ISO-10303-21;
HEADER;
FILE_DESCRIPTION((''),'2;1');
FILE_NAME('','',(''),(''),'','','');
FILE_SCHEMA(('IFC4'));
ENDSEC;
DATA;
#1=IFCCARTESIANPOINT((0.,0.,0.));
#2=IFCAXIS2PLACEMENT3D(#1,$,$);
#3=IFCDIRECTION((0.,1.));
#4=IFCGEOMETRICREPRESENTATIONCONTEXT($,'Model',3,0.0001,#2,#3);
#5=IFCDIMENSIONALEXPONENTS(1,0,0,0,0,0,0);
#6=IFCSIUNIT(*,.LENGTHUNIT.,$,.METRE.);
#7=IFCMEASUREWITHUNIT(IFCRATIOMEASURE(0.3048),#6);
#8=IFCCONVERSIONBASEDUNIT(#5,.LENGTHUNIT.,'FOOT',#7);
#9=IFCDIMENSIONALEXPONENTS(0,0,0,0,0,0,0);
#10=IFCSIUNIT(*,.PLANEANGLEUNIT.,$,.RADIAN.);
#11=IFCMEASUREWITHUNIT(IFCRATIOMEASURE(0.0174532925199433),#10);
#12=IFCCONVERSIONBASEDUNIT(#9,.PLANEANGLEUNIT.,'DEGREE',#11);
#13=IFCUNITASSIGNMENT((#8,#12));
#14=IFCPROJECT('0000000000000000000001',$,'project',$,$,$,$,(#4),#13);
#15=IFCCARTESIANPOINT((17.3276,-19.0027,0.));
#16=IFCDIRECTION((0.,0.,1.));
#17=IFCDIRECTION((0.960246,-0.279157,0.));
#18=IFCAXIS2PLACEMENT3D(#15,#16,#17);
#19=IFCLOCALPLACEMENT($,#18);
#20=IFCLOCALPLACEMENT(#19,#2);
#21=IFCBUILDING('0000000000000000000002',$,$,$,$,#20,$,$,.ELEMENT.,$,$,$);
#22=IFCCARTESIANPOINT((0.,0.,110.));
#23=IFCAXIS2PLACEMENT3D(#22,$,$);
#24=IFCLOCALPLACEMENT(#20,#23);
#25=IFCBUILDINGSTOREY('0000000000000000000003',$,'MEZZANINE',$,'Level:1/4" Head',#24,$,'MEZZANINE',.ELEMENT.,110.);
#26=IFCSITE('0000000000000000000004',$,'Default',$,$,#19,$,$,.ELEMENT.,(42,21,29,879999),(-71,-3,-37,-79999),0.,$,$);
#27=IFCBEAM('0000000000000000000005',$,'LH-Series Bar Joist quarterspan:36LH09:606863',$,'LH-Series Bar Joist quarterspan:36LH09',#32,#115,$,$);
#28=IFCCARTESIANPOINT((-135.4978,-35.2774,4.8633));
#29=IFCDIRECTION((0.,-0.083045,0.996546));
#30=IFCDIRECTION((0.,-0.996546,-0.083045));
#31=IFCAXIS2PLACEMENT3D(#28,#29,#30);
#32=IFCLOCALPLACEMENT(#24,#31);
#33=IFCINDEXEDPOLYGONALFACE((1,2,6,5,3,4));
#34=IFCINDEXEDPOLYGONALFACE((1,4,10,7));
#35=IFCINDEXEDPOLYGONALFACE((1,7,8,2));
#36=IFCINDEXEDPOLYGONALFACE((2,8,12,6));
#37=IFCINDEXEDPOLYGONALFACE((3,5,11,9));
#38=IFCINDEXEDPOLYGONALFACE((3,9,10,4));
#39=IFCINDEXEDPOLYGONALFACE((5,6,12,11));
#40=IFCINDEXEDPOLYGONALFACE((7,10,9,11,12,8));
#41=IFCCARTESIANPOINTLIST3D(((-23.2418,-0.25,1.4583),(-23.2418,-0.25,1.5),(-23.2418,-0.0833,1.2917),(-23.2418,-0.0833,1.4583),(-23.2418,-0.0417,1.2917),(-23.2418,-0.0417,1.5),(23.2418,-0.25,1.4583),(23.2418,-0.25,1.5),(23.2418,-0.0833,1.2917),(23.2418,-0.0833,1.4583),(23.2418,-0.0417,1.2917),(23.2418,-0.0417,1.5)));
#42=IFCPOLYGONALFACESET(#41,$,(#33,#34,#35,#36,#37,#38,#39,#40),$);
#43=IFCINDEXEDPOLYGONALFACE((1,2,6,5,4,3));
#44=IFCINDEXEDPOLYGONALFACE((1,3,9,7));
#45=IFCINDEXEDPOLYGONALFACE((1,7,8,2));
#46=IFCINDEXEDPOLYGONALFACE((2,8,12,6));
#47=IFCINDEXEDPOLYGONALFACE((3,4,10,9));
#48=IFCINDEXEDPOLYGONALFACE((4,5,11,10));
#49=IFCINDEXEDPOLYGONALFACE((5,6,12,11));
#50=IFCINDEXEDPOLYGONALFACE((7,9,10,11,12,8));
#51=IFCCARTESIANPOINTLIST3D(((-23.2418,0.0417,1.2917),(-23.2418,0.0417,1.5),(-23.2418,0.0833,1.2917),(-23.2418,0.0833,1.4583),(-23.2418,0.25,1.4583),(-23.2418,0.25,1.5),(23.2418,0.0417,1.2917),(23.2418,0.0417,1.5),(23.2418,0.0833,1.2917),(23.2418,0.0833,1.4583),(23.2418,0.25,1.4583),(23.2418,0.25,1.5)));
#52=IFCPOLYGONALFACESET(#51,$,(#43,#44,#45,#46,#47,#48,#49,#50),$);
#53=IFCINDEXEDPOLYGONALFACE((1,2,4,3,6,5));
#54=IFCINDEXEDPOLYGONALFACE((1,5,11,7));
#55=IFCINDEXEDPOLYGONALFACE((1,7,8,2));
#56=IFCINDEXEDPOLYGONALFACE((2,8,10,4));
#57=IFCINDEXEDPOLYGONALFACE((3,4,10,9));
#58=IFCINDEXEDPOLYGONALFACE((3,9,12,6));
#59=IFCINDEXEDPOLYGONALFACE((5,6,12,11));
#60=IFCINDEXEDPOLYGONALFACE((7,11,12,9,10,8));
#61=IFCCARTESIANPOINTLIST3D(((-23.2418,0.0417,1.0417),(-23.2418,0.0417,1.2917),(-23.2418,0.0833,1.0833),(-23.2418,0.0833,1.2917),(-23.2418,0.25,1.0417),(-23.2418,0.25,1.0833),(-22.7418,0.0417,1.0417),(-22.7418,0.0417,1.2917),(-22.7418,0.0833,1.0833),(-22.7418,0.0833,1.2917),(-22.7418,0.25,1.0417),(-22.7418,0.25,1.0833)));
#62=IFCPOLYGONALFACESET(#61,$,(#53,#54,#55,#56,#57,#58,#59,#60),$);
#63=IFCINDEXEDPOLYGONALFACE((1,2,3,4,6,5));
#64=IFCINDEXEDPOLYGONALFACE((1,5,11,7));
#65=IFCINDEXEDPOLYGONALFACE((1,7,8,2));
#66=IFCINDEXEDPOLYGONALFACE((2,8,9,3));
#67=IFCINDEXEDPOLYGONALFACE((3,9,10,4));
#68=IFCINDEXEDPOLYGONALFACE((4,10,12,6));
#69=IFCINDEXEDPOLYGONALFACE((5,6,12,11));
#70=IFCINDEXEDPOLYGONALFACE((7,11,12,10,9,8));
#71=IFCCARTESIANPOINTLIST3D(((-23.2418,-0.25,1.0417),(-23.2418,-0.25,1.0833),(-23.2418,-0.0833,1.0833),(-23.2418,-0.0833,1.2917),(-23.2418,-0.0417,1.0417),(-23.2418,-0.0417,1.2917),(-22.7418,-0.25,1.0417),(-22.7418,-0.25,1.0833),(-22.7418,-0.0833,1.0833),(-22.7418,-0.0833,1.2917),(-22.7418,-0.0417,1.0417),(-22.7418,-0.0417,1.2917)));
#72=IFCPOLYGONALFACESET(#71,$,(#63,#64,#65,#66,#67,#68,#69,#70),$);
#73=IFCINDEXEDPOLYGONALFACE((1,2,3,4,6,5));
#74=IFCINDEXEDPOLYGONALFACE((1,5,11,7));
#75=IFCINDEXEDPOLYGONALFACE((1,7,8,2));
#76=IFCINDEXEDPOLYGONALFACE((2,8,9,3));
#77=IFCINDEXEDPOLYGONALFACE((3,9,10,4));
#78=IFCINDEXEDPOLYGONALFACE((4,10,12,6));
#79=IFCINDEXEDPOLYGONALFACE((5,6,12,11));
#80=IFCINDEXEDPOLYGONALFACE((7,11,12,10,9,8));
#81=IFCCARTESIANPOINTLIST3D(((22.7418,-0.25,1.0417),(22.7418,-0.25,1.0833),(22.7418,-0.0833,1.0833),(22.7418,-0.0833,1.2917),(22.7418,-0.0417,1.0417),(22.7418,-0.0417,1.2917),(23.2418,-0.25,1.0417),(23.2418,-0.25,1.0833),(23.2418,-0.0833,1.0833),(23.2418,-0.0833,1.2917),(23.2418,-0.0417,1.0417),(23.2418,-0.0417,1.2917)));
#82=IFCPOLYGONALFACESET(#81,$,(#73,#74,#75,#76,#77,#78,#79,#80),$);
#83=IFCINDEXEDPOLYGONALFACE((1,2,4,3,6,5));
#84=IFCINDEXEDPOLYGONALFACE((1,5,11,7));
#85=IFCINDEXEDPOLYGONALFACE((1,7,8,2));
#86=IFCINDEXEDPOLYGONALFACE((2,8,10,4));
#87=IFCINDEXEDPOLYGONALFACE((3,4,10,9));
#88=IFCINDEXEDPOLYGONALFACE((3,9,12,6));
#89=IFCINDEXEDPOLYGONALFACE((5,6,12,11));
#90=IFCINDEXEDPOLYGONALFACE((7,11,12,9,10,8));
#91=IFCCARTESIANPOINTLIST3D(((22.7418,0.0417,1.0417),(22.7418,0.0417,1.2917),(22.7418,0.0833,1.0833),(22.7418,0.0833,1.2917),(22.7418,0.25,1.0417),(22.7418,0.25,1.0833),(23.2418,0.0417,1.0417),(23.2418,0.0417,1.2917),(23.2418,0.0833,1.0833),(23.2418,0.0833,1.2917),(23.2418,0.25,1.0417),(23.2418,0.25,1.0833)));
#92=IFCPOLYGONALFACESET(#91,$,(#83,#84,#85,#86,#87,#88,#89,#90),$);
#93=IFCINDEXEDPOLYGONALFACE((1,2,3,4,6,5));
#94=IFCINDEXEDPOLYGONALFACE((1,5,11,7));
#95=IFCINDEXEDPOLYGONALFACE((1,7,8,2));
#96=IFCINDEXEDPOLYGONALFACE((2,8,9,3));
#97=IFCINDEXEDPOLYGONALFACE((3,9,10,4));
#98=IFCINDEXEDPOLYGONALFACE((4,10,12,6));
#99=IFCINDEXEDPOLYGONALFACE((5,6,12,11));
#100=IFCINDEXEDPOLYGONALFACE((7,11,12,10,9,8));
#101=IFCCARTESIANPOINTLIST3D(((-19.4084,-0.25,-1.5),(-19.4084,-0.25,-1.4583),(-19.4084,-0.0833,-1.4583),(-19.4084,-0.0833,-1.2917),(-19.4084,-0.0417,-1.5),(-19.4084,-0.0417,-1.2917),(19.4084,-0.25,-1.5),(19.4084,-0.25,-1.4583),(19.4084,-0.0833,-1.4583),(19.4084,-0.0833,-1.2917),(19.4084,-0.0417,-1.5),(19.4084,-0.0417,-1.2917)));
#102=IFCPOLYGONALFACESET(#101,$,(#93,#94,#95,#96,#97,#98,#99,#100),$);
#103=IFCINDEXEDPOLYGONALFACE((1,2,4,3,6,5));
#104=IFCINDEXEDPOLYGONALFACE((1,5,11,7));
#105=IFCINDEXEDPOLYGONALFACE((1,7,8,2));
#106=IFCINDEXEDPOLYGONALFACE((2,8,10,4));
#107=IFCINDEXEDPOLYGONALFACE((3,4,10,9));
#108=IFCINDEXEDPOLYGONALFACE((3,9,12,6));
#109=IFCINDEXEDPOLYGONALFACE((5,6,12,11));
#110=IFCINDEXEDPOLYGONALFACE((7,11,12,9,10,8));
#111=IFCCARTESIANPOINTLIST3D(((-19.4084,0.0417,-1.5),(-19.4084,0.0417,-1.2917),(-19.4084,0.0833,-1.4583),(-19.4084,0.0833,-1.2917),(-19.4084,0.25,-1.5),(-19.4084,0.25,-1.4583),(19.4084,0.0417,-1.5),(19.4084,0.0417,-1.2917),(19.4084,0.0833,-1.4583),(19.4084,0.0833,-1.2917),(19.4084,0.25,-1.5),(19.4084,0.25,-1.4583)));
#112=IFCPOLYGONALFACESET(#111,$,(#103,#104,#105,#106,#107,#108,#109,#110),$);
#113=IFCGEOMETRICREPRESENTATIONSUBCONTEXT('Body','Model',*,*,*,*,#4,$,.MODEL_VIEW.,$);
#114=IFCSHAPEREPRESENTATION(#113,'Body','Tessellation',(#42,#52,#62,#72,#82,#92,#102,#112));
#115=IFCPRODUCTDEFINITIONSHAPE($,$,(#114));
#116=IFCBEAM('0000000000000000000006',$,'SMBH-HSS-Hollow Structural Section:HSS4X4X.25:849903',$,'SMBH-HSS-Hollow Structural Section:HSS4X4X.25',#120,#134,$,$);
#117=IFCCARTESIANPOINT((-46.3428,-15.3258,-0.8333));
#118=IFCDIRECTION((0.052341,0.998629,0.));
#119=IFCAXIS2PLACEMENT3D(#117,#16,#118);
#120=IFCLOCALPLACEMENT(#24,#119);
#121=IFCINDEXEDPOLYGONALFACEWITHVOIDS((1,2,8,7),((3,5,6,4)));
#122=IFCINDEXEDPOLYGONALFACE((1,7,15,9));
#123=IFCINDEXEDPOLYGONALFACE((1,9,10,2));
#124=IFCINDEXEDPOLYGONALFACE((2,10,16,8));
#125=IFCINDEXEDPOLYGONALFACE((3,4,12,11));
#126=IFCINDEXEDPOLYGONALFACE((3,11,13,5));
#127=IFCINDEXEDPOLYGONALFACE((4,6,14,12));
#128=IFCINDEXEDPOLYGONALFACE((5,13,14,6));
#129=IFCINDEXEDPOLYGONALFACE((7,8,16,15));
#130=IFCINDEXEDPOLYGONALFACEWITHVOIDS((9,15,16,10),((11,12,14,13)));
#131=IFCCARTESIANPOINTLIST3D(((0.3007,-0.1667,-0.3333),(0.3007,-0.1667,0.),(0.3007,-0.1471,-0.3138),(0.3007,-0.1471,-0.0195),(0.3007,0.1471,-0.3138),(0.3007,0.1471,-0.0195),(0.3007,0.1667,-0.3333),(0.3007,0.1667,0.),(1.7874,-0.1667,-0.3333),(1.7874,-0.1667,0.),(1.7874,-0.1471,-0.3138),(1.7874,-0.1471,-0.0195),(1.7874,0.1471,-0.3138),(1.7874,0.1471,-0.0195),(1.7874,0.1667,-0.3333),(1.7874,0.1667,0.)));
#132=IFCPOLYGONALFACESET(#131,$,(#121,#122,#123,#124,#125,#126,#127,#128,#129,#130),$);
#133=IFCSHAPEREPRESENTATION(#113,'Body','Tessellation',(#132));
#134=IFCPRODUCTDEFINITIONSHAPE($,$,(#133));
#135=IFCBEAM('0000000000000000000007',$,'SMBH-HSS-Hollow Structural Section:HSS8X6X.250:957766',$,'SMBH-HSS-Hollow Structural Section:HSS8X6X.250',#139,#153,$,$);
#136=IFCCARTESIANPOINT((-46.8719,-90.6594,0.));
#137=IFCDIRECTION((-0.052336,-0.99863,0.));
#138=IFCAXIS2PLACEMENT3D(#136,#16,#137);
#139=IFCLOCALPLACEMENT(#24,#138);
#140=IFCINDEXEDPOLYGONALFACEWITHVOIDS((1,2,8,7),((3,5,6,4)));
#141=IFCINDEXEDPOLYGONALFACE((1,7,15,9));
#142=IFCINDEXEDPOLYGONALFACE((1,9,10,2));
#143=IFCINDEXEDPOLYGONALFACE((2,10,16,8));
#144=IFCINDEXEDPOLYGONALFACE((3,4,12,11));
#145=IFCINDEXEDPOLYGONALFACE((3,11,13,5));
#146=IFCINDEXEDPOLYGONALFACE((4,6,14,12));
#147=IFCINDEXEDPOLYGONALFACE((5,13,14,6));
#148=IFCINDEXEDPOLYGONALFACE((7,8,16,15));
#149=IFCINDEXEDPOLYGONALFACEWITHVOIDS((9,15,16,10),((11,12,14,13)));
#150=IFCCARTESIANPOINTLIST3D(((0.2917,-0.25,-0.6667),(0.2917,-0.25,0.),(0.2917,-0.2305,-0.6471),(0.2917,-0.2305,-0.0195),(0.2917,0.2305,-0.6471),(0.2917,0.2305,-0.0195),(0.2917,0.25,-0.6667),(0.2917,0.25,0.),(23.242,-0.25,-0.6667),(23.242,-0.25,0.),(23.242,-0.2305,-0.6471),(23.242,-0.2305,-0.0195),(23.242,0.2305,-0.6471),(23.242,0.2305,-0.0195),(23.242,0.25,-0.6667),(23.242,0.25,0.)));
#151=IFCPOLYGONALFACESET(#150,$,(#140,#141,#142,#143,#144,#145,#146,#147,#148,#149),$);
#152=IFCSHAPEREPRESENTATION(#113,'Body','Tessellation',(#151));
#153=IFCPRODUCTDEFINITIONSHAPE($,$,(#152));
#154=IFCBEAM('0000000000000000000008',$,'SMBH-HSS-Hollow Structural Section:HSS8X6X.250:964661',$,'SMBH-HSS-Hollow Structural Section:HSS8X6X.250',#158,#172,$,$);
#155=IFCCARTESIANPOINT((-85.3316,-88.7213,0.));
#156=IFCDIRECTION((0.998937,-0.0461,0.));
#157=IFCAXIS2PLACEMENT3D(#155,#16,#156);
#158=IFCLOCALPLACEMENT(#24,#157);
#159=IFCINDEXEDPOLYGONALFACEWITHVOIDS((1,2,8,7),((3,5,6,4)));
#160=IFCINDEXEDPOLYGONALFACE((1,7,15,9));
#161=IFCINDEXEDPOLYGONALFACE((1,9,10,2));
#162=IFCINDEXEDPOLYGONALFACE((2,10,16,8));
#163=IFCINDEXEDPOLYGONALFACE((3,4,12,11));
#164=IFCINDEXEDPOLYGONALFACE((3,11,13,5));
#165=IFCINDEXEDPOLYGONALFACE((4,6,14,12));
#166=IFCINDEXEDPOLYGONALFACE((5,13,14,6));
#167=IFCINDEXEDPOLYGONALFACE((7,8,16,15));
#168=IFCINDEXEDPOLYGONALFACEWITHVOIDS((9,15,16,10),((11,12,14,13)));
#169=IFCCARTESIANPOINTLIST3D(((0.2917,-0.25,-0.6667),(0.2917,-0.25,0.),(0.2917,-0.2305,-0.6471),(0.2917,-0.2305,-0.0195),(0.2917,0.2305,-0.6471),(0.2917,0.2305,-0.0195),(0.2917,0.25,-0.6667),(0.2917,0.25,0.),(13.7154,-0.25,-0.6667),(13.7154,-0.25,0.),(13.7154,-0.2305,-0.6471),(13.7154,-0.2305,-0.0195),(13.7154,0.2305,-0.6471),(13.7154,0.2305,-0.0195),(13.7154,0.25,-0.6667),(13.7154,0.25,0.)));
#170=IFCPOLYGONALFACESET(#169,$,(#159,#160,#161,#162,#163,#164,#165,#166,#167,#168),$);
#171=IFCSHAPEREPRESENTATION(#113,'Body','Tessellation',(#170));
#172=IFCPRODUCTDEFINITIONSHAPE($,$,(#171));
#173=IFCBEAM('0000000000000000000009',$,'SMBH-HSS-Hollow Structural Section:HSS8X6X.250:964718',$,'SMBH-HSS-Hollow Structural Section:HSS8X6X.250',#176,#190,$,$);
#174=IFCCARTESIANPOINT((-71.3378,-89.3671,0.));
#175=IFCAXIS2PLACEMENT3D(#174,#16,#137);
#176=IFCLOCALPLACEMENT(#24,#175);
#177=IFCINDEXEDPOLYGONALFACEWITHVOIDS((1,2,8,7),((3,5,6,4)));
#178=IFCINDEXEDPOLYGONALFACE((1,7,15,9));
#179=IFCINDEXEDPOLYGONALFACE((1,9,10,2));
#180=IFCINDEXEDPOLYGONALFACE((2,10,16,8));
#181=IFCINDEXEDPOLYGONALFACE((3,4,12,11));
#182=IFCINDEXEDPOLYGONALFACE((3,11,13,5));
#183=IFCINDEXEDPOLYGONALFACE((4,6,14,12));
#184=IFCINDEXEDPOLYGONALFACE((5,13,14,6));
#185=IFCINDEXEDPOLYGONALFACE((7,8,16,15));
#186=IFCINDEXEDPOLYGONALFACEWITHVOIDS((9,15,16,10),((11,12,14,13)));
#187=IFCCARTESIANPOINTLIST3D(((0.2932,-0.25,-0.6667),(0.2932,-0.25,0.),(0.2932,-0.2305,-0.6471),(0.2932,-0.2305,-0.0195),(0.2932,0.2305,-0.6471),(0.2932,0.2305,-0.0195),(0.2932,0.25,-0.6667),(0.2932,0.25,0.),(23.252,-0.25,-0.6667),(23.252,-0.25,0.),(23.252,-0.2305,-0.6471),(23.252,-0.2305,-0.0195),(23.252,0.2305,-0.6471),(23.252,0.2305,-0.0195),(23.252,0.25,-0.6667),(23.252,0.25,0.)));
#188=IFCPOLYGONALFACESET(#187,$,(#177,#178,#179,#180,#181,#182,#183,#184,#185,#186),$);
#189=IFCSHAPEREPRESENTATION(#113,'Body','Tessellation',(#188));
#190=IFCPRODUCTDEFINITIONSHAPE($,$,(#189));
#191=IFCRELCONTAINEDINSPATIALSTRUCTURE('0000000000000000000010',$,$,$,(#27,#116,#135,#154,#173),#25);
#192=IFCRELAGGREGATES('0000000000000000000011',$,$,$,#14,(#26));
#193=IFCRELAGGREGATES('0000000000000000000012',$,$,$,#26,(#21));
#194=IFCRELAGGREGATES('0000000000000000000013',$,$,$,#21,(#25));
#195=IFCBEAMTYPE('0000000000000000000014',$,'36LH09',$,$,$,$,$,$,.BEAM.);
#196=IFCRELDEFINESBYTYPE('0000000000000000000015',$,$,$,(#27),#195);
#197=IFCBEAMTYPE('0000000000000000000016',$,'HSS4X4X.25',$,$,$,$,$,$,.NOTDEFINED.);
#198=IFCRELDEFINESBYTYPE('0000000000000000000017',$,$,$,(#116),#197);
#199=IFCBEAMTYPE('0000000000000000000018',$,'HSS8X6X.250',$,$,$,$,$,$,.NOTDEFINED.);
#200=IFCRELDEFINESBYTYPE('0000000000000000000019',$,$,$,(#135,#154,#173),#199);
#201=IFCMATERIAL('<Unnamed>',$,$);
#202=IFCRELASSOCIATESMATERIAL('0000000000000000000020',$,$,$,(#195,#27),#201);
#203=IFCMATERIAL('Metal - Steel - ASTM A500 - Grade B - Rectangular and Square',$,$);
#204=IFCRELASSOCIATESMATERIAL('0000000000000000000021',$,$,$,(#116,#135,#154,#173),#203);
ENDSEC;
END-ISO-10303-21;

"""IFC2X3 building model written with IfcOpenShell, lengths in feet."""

from ifc_helpers import new_model, entity, si_unit, converted_unit, direction, frame, frame_2d, origin, place, context, subcontext, project, spatial, polyline, rectangle, outline, extrude, boolean, source, transform, mapped, material, type_object, type_shapes, element, save


model = new_model("IFC2X3")

# Units and contexts
model_context = context("Model", 3, precision=0.0001, world=origin(), true_north=direction((0.0, 1.0)))
body_context = subcontext(model_context, "Body", "Model", "MODEL_VIEW")
ifc_project = project(units=[converted_unit("LENGTHUNIT", "FOOT", entity("IfcRatioMeasure", 0.3048), si_unit("LENGTHUNIT", "METRE"), dimensions=[1, 0, 0, 0, 0, 0, 0]), converted_unit("PLANEANGLEUNIT", "DEGREE", entity("IfcRatioMeasure", 0.0174532925199433), si_unit("PLANEANGLEUNIT", "RADIAN"), dimensions=[0, 0, 0, 0, 0, 0, 0])], contexts=[model_context])

# Site, building, storey
site_placement = place(None, frame((17.3276, -19.0027, 0.0), z_axis=(0.0, 0.0, 1.0), x_axis=(0.960246, -0.279157, 0.0)))
site = spatial("IfcSite", under=ifc_project, at=site_placement, Name="Default", CompositionType="ELEMENT", RefLatitude=(42, 21, 29, 879999), RefLongitude=(-71, -3, -37, -79999), RefElevation=0.0)
building_placement = place(site_placement, origin())
building = spatial("IfcBuilding", under=site, at=building_placement, CompositionType="ELEMENT")
storey_placement = place(building_placement, frame((0.0, 0.0, 110.0)))
storey = spatial("IfcBuildingStorey", under=building, at=storey_placement, Name="MEZZANINE", ObjectType="Level:1/4\" Head", LongName="MEZZANINE", CompositionType="ELEMENT", Elevation=110.0)

# Beams
ifc_material_1 = material(Name="Metal - Steel - ASTM A500 - Grade B - Rectangular and Square")
ifc_material_2 = material(Name="<Unnamed>")
beam_type_1 = type_object("IfcBeamType", Name="36LH09", PredefinedType="BEAM", material=ifc_material_2)
shared_shape = source(origin(), body_context, "Body", "SweptSolid", [
    extrude(outline(polyline([(-0.0833, -0.125), (-0.0417, -0.125), (-0.0417, 0.0417), (0.125, 0.0417), (0.125, 0.0833), (-0.0833, 0.0833), (-0.0833, -0.125)])), frame((-23.2418, -0.125, 1.4167), z_axis=(1.0, 0.0, 0.0), x_axis=(0.0, 0.0, -1.0)), (0.0, 0.0, 1.0), 46.4835),
    extrude(outline(polyline([(-0.0833, -0.0833), (0.125, -0.0833), (0.125, -0.0417), (-0.0417, -0.0417), (-0.0417, 0.125), (-0.0833, 0.125), (-0.0833, -0.0833)])), frame((-23.2418, 0.125, 1.4167), z_axis=(1.0, 0.0, 0.0), x_axis=(0.0, 0.0, -1.0)), (0.0, 0.0, 1.0), 46.4835),
    extrude(outline(polyline([(-0.1528, -0.0833), (0.0972, -0.0833), (0.0972, 0.125), (0.0556, 0.125), (0.0556, -0.0417), (-0.1528, -0.0417), (-0.1528, -0.0833)])), frame((-23.2418, 0.125, 1.1389), z_axis=(1.0, 0.0, 0.0), x_axis=(0.0, 0.0, -1.0)), (0.0, 0.0, 1.0), 0.5),
    extrude(outline(polyline([(0.0556, -0.125), (0.0972, -0.125), (0.0972, 0.0833), (-0.1528, 0.0833), (-0.1528, 0.0417), (0.0556, 0.0417), (0.0556, -0.125)])), frame((-23.2418, -0.125, 1.1389), z_axis=(1.0, 0.0, 0.0), x_axis=(0.0, 0.0, -1.0)), (0.0, 0.0, 1.0), 0.5),
    extrude(outline(polyline([(0.0556, -0.125), (0.0972, -0.125), (0.0972, 0.0833), (-0.1528, 0.0833), (-0.1528, 0.0417), (0.0556, 0.0417), (0.0556, -0.125)])), frame((22.7418, -0.125, 1.1389), z_axis=(1.0, 0.0, 0.0), x_axis=(0.0, 0.0, -1.0)), (0.0, 0.0, 1.0), 0.5),
    extrude(outline(polyline([(-0.1528, -0.0833), (0.0972, -0.0833), (0.0972, 0.125), (0.0556, 0.125), (0.0556, -0.0417), (-0.1528, -0.0417), (-0.1528, -0.0833)])), frame((22.7418, 0.125, 1.1389), z_axis=(1.0, 0.0, 0.0), x_axis=(0.0, 0.0, -1.0)), (0.0, 0.0, 1.0), 0.5),
    extrude(outline(polyline([(0.0417, -0.125), (0.0833, -0.125), (0.0833, 0.0833), (-0.125, 0.0833), (-0.125, 0.0417), (0.0417, 0.0417), (0.0417, -0.125)])), frame((-19.4084, -0.125, -1.4167), z_axis=(1.0, 0.0, 0.0), x_axis=(0.0, 0.0, -1.0)), (0.0, 0.0, 1.0), 38.8169),
    extrude(outline(polyline([(-0.125, -0.0833), (0.0833, -0.0833), (0.0833, 0.125), (0.0417, 0.125), (0.0417, -0.0417), (-0.125, -0.0417), (-0.125, -0.0833)])), frame((-19.4084, 0.125, -1.4167), z_axis=(1.0, 0.0, 0.0), x_axis=(0.0, 0.0, -1.0)), (0.0, 0.0, 1.0), 38.8169),
])
type_shapes(beam_type_1, [shared_shape])
beam_1_placement = place(storey_placement, frame((-135.4978, -35.2774, 4.8633), z_axis=(0.0, -0.083045, 0.996546), x_axis=(0.0, -0.996546, -0.083045)))
element("IfcBeam", 1, at=beam_1_placement, inside=storey, type_object=beam_type_1, material=ifc_material_2, Name="LH-Series Bar Joist quarterspan:36LH09:606863", ObjectType="LH-Series Bar Joist quarterspan:36LH09", context=body_context, shape_type="MappedRepresentation", body=[
    mapped(shared_shape, transform((0.0, 0.0, 0.0), scale=1.0)),
])
beam_type_2 = type_object("IfcBeamType", Name="HSS4X4X.25", PredefinedType="NOTDEFINED")
beam_2_placement = place(storey_placement, frame((-46.3428, -15.3258, -0.8333), z_axis=(0.0, 0.0, 1.0), x_axis=(0.052341, 0.998629, 0.0)))
element("IfcBeam", 2, at=beam_2_placement, inside=storey, type_object=beam_type_2, material=ifc_material_1, Name="SMBH-HSS-Hollow Structural Section:HSS4X4X.25:849903", ObjectType="SMBH-HSS-Hollow Structural Section:HSS4X4X.25", context=body_context, shape_type="SweptSolid", body=[
    boolean("DIFFERENCE", extrude(rectangle(XDim=0.3333, YDim=0.3333, at=frame_2d((0.0, 0.0), x_axis=(1.0, 0.0))), frame((0.3007, 0.0, -0.1667), z_axis=(1.0, 0.0, 0.0), x_axis=(0.0, 0.0, -1.0)), (0.0, 0.0, 1.0), 1.4867), extrude(rectangle(XDim=0.2943, YDim=0.2943, at=frame_2d((0.0, 0.0), x_axis=(0.0, 1.0))), frame((1.7874, 0.0, -0.1667), z_axis=(-1.0, 0.0, 0.0), x_axis=(0.0, 1.0, 0.0)), (0.0, 0.0, 1.0), 1.4867)),
])
beam_type_3 = type_object("IfcBeamType", Name="HSS8X6X.250", PredefinedType="NOTDEFINED")
beam_3_placement = place(storey_placement, frame((-46.8719, -90.6594, 0.0), z_axis=(0.0, 0.0, 1.0), x_axis=(-0.052336, -0.99863, 0.0)))
element("IfcBeam", 3, at=beam_3_placement, inside=storey, type_object=beam_type_3, material=ifc_material_1, Name="SMBH-HSS-Hollow Structural Section:HSS8X6X.250:957766", ObjectType="SMBH-HSS-Hollow Structural Section:HSS8X6X.250", context=body_context, shape_type="SweptSolid", body=[
    boolean("DIFFERENCE", extrude(rectangle(XDim=0.6667, YDim=0.5, at=frame_2d((0.0, 0.0), x_axis=(1.0, 0.0))), frame((0.2917, 0.0, -0.3333), z_axis=(1.0, 0.0, 0.0), x_axis=(0.0, 0.0, -1.0)), (0.0, 0.0, 1.0), 22.9503), extrude(rectangle(XDim=0.6276, YDim=0.4609, at=frame_2d((0.0, 0.0), x_axis=(0.0, 1.0))), frame((23.242, 0.0, -0.3333), z_axis=(-1.0, 0.0, 0.0), x_axis=(0.0, 1.0, 0.0)), (0.0, 0.0, 1.0), 22.9503)),
])
beam_4_placement = place(storey_placement, frame((-85.3316, -88.7213, 0.0), z_axis=(0.0, 0.0, 1.0), x_axis=(0.998937, -0.0461, 0.0)))
element("IfcBeam", 4, at=beam_4_placement, inside=storey, type_object=beam_type_3, material=ifc_material_1, Name="SMBH-HSS-Hollow Structural Section:HSS8X6X.250:964661", ObjectType="SMBH-HSS-Hollow Structural Section:HSS8X6X.250", context=body_context, shape_type="SweptSolid", body=[
    boolean("DIFFERENCE", extrude(rectangle(XDim=0.6667, YDim=0.5, at=frame_2d((0.0, 0.0), x_axis=(1.0, 0.0))), frame((0.2917, 0.0, -0.3333), z_axis=(1.0, 0.0, 0.0), x_axis=(0.0, 0.0, -1.0)), (0.0, 0.0, 1.0), 13.4237), extrude(rectangle(XDim=0.6276, YDim=0.4609, at=frame_2d((0.0, 0.0), x_axis=(0.0, 1.0))), frame((13.7154, 0.0, -0.3333), z_axis=(-1.0, 0.0, 0.0), x_axis=(0.0, 1.0, 0.0)), (0.0, 0.0, 1.0), 13.4237)),
])
beam_5_placement = place(storey_placement, frame((-71.3378, -89.3671, 0.0), z_axis=(0.0, 0.0, 1.0), x_axis=(-0.052336, -0.99863, 0.0)))
element("IfcBeam", 5, at=beam_5_placement, inside=storey, type_object=beam_type_3, material=ifc_material_1, Name="SMBH-HSS-Hollow Structural Section:HSS8X6X.250:964718", ObjectType="SMBH-HSS-Hollow Structural Section:HSS8X6X.250", context=body_context, shape_type="SweptSolid", body=[
    boolean("DIFFERENCE", extrude(rectangle(XDim=0.6667, YDim=0.5, at=frame_2d((0.0, 0.0), x_axis=(1.0, 0.0))), frame((0.2932, 0.0, -0.3333), z_axis=(1.0, 0.0, 0.0), x_axis=(0.0, 0.0, -1.0)), (0.0, 0.0, 1.0), 22.9588), extrude(rectangle(XDim=0.6276, YDim=0.4609, at=frame_2d((0.0, 0.0), x_axis=(0.0, 1.0))), frame((23.252, 0.0, -0.3333), z_axis=(-1.0, 0.0, 0.0), x_axis=(0.0, 1.0, 0.0)), (0.0, 0.0, 1.0), 22.9588)),
])

save(model, "model.ifc")
